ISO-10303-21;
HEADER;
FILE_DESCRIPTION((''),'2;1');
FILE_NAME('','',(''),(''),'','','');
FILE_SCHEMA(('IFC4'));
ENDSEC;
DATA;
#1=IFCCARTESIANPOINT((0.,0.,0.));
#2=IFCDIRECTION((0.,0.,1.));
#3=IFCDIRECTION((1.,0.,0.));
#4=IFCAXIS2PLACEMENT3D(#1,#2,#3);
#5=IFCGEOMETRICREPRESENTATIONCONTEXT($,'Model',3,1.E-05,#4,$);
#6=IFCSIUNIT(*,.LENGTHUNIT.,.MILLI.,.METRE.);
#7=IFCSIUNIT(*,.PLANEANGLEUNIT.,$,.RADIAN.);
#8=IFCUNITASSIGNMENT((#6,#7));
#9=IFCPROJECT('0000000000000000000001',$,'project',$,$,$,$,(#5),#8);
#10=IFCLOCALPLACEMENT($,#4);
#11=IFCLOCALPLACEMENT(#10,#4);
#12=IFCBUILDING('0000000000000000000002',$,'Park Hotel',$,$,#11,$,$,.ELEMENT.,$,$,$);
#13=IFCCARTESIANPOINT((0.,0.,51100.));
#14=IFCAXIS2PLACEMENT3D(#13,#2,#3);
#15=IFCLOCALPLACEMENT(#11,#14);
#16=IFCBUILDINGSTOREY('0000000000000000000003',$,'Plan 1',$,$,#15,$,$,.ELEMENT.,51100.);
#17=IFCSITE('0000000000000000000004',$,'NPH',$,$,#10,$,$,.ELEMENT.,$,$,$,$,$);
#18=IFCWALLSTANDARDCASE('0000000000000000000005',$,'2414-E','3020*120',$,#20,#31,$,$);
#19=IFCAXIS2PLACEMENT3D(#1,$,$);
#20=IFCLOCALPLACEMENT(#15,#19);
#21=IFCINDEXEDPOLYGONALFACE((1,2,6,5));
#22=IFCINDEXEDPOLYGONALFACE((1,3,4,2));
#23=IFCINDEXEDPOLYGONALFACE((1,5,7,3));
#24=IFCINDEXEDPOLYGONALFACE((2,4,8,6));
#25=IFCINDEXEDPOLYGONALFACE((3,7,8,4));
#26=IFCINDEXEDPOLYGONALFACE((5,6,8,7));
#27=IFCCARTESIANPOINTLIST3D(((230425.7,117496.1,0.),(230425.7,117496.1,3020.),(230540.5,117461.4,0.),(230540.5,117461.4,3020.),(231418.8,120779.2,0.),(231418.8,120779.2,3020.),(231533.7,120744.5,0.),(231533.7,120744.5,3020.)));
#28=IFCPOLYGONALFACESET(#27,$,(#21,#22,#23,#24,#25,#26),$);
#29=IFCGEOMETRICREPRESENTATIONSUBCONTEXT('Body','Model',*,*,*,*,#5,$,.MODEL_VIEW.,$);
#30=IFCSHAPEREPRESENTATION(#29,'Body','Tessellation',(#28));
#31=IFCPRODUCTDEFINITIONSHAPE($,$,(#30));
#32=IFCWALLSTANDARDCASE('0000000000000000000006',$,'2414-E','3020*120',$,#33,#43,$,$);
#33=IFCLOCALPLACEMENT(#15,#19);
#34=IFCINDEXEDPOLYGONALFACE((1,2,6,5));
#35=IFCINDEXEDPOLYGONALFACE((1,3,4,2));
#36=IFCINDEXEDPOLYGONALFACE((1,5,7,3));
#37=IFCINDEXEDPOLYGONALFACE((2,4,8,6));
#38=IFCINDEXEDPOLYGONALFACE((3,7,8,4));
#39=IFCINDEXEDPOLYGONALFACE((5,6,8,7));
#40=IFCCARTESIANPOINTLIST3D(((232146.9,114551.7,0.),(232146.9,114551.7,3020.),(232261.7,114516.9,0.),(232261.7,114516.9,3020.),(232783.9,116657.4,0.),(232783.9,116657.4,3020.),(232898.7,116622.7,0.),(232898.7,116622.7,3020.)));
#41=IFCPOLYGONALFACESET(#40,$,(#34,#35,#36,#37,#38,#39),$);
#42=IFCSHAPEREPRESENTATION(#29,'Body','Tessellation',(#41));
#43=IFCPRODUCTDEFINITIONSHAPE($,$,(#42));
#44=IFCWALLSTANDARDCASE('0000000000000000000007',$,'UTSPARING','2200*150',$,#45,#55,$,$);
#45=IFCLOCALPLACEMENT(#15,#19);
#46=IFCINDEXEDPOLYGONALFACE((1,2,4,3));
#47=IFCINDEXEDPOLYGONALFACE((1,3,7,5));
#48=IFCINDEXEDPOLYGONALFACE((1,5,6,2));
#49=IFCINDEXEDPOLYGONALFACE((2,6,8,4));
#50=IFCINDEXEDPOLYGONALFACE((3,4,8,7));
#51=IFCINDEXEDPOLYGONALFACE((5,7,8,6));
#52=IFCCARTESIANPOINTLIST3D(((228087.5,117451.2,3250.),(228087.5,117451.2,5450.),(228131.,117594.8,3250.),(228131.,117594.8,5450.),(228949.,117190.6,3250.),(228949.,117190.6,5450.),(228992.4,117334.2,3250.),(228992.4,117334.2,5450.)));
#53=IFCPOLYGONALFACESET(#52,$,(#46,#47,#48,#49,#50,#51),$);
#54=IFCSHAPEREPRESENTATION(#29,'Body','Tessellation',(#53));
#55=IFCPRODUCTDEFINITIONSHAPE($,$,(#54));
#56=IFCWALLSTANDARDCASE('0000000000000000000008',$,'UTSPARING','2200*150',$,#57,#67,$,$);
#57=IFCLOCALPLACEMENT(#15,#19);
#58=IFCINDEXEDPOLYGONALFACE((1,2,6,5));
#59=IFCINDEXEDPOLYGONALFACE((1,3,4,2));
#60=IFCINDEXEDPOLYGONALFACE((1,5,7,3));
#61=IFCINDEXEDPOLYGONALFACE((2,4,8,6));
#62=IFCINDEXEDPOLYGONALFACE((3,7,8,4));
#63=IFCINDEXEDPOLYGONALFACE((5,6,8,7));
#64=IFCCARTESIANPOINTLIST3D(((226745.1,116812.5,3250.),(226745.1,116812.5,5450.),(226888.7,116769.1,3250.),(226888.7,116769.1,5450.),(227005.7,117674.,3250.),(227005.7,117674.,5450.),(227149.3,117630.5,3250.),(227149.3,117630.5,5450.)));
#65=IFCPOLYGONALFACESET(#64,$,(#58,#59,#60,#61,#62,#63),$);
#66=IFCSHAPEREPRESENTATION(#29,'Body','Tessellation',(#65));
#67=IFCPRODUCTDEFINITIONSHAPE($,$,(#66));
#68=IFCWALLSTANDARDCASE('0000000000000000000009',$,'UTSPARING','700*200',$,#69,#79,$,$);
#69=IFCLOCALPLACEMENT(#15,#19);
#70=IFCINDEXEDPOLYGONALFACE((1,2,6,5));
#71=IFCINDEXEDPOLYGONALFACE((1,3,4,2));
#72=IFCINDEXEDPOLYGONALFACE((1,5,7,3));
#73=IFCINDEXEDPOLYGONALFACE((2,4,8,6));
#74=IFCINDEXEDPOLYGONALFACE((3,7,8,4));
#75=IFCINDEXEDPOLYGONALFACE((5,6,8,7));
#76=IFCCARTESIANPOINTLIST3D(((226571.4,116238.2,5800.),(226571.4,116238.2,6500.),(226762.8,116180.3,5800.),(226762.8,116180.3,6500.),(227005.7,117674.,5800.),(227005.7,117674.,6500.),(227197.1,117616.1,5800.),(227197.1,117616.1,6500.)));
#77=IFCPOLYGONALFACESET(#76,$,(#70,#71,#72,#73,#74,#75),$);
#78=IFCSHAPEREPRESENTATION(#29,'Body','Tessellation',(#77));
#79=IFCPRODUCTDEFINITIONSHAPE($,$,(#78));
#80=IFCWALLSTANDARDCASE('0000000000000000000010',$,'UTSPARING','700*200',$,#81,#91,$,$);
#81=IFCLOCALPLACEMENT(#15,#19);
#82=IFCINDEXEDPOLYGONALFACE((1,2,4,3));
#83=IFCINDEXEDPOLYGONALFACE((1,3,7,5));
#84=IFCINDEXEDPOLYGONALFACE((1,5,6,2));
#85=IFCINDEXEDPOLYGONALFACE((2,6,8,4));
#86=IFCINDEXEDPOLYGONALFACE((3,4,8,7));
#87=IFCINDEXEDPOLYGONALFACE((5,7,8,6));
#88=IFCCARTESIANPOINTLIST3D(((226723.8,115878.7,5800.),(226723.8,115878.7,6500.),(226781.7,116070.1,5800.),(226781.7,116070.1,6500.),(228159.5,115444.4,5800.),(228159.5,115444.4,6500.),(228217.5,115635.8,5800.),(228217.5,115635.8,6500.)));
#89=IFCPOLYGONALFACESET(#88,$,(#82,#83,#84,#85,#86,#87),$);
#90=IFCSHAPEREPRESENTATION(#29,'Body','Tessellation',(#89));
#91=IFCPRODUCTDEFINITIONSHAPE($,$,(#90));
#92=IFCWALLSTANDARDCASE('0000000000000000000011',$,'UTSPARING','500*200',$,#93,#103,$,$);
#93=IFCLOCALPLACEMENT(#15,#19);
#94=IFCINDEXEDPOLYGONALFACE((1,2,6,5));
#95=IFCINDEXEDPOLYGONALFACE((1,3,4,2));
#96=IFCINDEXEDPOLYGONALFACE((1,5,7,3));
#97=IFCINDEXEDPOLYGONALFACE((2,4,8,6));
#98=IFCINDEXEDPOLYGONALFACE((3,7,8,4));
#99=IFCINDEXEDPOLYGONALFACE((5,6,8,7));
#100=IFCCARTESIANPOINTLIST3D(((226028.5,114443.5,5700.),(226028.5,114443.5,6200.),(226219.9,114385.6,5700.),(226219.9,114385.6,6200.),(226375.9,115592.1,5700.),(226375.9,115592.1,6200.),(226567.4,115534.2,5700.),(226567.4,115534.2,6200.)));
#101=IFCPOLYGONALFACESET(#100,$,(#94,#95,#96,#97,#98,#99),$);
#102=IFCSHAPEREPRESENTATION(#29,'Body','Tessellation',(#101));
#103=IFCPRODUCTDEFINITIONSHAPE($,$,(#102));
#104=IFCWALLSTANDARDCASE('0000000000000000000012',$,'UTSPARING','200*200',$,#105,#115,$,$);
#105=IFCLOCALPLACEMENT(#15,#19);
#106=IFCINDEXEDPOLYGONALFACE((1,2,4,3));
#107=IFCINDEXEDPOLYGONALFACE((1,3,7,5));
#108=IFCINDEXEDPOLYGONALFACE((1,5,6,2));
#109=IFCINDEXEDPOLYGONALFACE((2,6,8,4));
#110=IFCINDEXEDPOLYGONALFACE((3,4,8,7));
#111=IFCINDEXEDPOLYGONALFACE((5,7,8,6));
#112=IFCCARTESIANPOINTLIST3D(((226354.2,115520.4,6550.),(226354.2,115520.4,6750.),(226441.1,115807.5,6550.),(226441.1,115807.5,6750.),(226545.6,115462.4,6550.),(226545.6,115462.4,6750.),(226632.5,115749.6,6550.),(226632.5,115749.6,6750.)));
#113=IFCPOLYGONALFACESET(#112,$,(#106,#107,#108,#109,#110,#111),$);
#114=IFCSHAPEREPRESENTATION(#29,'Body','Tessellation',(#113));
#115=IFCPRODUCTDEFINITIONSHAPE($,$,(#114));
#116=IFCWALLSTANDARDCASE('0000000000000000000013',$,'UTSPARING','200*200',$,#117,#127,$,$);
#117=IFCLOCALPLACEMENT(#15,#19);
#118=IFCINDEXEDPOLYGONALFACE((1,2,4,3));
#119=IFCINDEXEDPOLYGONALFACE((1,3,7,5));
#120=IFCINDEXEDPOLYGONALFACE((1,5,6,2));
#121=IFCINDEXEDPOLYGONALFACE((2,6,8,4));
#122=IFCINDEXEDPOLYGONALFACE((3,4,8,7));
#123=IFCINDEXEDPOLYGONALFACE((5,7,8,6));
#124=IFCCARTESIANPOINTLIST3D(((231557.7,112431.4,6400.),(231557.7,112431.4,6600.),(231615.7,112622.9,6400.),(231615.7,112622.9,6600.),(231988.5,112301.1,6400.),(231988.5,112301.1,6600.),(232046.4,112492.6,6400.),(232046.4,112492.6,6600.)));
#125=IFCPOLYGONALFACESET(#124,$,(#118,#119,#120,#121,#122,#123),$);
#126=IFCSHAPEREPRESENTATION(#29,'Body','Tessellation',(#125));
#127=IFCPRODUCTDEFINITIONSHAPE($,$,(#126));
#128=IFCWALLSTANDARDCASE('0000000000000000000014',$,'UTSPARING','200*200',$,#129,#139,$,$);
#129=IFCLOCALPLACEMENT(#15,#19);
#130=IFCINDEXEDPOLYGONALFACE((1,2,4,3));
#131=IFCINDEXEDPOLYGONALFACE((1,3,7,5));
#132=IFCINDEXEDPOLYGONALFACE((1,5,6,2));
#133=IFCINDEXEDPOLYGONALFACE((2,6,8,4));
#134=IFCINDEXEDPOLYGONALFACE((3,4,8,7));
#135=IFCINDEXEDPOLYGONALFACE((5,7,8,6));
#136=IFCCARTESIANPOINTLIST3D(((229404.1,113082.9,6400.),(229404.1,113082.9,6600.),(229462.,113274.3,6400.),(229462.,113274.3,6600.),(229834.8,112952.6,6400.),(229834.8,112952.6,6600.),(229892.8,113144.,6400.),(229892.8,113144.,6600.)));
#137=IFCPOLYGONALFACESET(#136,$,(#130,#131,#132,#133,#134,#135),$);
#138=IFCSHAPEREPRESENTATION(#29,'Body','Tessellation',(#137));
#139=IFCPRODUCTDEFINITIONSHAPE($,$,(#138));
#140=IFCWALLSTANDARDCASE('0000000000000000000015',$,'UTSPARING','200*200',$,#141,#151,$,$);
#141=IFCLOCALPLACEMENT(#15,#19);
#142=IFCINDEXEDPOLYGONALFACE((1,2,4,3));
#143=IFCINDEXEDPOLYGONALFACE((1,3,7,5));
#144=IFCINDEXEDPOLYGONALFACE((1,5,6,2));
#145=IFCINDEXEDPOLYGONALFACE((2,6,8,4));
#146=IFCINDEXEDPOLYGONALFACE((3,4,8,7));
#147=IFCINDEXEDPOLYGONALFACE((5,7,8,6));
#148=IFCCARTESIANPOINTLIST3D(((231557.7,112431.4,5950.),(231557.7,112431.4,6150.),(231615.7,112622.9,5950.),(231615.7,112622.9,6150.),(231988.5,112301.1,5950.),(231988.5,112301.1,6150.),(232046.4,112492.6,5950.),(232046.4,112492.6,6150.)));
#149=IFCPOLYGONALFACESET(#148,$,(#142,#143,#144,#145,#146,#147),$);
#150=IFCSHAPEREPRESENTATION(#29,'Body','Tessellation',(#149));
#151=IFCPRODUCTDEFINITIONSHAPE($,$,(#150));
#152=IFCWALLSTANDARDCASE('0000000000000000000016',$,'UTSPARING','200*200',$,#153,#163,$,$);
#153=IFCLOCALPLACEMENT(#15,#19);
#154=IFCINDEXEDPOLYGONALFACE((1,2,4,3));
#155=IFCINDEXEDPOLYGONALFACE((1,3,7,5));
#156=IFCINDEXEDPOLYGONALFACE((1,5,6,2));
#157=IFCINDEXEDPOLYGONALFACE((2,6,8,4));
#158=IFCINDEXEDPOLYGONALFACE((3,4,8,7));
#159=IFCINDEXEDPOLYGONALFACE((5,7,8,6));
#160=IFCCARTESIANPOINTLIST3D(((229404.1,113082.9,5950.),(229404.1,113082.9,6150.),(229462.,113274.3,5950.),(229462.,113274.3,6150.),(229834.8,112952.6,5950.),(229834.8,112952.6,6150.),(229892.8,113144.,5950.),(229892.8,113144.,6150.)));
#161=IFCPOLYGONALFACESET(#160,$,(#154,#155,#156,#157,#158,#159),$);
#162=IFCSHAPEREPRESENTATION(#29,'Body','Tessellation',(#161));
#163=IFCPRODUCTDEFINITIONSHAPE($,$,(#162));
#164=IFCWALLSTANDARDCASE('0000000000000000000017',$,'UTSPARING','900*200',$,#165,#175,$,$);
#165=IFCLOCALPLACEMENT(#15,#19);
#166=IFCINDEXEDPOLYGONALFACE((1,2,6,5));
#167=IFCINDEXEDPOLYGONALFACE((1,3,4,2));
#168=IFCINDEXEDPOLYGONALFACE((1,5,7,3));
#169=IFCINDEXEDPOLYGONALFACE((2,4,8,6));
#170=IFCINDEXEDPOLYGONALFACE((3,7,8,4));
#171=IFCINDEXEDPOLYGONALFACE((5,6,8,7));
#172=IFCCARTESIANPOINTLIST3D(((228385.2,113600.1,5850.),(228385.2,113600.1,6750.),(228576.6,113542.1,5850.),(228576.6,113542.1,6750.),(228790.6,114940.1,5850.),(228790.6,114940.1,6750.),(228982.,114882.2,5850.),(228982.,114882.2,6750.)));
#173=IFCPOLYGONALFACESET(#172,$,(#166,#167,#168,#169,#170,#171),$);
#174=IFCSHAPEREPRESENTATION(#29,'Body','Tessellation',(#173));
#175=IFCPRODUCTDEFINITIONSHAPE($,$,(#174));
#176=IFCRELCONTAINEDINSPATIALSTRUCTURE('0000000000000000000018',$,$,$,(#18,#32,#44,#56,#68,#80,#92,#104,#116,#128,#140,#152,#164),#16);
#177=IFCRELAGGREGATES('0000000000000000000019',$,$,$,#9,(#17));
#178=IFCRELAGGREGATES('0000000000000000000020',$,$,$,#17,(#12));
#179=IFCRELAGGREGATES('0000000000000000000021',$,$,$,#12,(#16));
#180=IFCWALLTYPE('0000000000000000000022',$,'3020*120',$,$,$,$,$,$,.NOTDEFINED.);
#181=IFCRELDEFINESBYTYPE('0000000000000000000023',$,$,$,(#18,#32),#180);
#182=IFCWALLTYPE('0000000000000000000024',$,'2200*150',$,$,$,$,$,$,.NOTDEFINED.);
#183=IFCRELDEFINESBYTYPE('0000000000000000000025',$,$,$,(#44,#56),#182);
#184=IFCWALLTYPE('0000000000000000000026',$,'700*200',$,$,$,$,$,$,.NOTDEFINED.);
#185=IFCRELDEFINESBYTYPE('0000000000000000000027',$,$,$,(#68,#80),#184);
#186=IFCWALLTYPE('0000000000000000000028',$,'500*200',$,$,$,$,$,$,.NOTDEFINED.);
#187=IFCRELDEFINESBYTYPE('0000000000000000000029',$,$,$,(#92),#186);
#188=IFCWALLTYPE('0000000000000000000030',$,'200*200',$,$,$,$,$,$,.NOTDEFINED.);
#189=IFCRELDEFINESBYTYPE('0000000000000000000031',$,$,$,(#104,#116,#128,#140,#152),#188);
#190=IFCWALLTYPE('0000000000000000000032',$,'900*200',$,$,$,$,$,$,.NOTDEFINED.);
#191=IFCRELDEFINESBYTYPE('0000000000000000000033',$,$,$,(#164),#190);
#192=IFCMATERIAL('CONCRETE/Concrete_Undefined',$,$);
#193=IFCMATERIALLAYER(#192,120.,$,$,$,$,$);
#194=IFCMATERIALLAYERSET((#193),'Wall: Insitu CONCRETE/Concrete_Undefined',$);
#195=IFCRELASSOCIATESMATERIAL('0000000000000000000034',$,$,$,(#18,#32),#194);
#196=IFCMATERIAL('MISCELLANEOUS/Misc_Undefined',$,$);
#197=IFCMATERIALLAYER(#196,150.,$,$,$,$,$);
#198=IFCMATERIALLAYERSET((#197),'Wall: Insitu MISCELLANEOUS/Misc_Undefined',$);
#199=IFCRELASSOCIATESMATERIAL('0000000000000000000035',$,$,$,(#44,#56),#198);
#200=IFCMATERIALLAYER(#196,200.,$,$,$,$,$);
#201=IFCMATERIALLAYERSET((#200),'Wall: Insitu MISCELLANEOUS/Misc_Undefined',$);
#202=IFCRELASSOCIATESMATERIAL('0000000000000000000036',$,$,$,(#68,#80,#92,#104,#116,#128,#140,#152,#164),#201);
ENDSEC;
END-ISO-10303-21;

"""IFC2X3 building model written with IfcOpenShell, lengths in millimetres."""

from ifc_helpers import new_model, si_unit, frame, frame_2d, origin_with_axes, place, context, subcontext, project, spatial, rectangle, extrude, material, layer, layer_set, layer_usage, type_object, element, save


model = new_model("IFC2X3")

# Units and contexts
model_context = context("Model", 3, precision=1e-05, world=origin_with_axes())
body_context = subcontext(model_context, "Body", "Model", "MODEL_VIEW")
ifc_project = project(units=[si_unit("LENGTHUNIT", "METRE", prefix="MILLI"), si_unit("PLANEANGLEUNIT", "RADIAN")], contexts=[model_context])

# Site, building, storey
site_placement = place(None, origin_with_axes())
site = spatial("IfcSite", under=ifc_project, at=site_placement, Name="NPH", CompositionType="ELEMENT")
building_placement = place(site_placement, origin_with_axes())
building = spatial("IfcBuilding", under=site, at=building_placement, Name="Park Hotel", CompositionType="ELEMENT")
storey_placement = place(building_placement, frame((0.0, 0.0, 51100.0), z_axis=(0.0, 0.0, 1.0), x_axis=(1.0, 0.0, 0.0)))
storey = spatial("IfcBuildingStorey", under=building, at=storey_placement, Name="Plan 1", CompositionType="ELEMENT", Elevation=51100.0)

# Shared definitions
ifc_material_1 = material(Name="CONCRETE/Concrete_Undefined")

# Walls
ifc_material_2 = material(Name="MISCELLANEOUS/Misc_Undefined")
ifc_layer_1 = layer(ifc_material_2, 150.0)
ifc_layer_set_1 = layer_set([ifc_layer_1], Name="Wall: Insitu MISCELLANEOUS/Misc_Undefined")
ifc_layer_2 = layer(ifc_material_1, 120.0)
ifc_layer_set_2 = layer_set([ifc_layer_2], Name="Wall: Insitu CONCRETE/Concrete_Undefined")
ifc_layer_usage_1 = layer_usage(ifc_layer_set_2, "AXIS2", "POSITIVE", -60.0)
wall_type_1 = type_object("IfcWallType", Name="3020*120", PredefinedType="NOTDEFINED")
wall_1_placement = place(storey_placement, frame((230483.1, 117478.8, 0.0), z_axis=(0.0, 0.0, 1.0), x_axis=(0.289539, 0.957166, 0.0)))
element("IfcWallStandardCase", 1, at=wall_1_placement, inside=storey, type_object=wall_type_1, material=ifc_layer_usage_1, Name="2414-E", Description="3020*120", context=body_context, shape_type="SweptSolid", body=[
    extrude(rectangle(XDim=3430.0, YDim=120.0, at=frame_2d((0.0, 1715.0), x_axis=(0.0, -1.0))), frame((0.0, 0.0, 0.0), z_axis=(0.0, 0.0, 1.0), x_axis=(0.0, -1.0, 0.0)), (0.0, 0.0, 1.0), 3020.0),
])
ifc_layer_usage_2 = layer_usage(ifc_layer_set_2, "AXIS2", "POSITIVE", -60.0)
wall_2_placement = place(storey_placement, frame((232204.3, 114534.3, 0.0), z_axis=(0.0, 0.0, 1.0), x_axis=(0.289541, 0.957166, 0.0)))
element("IfcWallStandardCase", 2, at=wall_2_placement, inside=storey, type_object=wall_type_1, material=ifc_layer_usage_2, Name="2414-E", Description="3020*120", context=body_context, shape_type="SweptSolid", body=[
    extrude(rectangle(XDim=2200.0, YDim=120.0, at=frame_2d((0.0, 1100.0), x_axis=(0.0, -1.0))), frame((0.0, 0.0, 0.0), z_axis=(0.0, 0.0, 1.0), x_axis=(0.0, -1.0, 0.0)), (0.0, 0.0, 1.0), 3020.0),
])
ifc_layer_usage_3 = layer_usage(ifc_layer_set_1, "AXIS2", "POSITIVE", -75.0)
wall_type_2 = type_object("IfcWallType", Name="2200*150", PredefinedType="NOTDEFINED")
wall_3_placement = place(storey_placement, frame((228970.7, 117262.4, 3250.0), z_axis=(0.0, 0.0, 1.0), x_axis=(-0.957165, 0.289542, 0.0)))
element("IfcWallStandardCase", 3, at=wall_3_placement, inside=storey, type_object=wall_type_2, material=ifc_layer_usage_3, Name="UTSPARING", Description="2200*150", context=body_context, shape_type="SweptSolid", body=[
    extrude(rectangle(XDim=900.0, YDim=150.0, at=frame_2d((0.0, 450.0), x_axis=(0.0, -1.0))), frame((0.0, 0.0, 0.0), z_axis=(0.0, 0.0, 1.0), x_axis=(0.0, -1.0, 0.0)), (0.0, 0.0, 1.0), 2200.0),
])
ifc_layer_usage_4 = layer_usage(ifc_layer_set_1, "AXIS2", "POSITIVE", -75.0)
wall_4_placement = place(storey_placement, frame((226816.9, 116790.8, 3250.0), z_axis=(0.0, 0.0, 1.0), x_axis=(0.289542, 0.957165, 0.0)))
element("IfcWallStandardCase", 4, at=wall_4_placement, inside=storey, type_object=wall_type_2, material=ifc_layer_usage_4, Name="UTSPARING", Description="2200*150", context=body_context, shape_type="SweptSolid", body=[
    extrude(rectangle(XDim=900.0, YDim=150.0, at=frame_2d((0.0, 450.0), x_axis=(0.0, -1.0))), frame((0.0, 0.0, 0.0), z_axis=(0.0, 0.0, 1.0), x_axis=(0.0, -1.0, 0.0)), (0.0, 0.0, 1.0), 2200.0),
])
ifc_layer_3 = layer(ifc_material_2, 200.0)
ifc_layer_set_3 = layer_set([ifc_layer_3], Name="Wall: Insitu MISCELLANEOUS/Misc_Undefined")
ifc_layer_usage_5 = layer_usage(ifc_layer_set_3, "AXIS2", "POSITIVE", -100.0)
wall_type_3 = type_object("IfcWallType", Name="700*200", PredefinedType="NOTDEFINED")
wall_5_placement = place(storey_placement, frame((227101.4, 117645.0, 5800.0), z_axis=(0.0, 0.0, 1.0), x_axis=(-0.289539, -0.957166, 0.0)))
element("IfcWallStandardCase", 5, at=wall_5_placement, inside=storey, type_object=wall_type_3, material=ifc_layer_usage_5, Name="UTSPARING", Description="700*200", context=body_context, shape_type="SweptSolid", body=[
    extrude(rectangle(XDim=1500.0, YDim=200.0, at=frame_2d((0.0, 750.0), x_axis=(0.0, -1.0))), frame((0.0, 0.0, 0.0), z_axis=(0.0, 0.0, 1.0), x_axis=(0.0, -1.0, 0.0)), (0.0, 0.0, 1.0), 700.0),
])
ifc_layer_usage_6 = layer_usage(ifc_layer_set_3, "AXIS2", "POSITIVE", -100.0)
wall_6_placement = place(storey_placement, frame((228188.5, 115540.1, 5800.0), z_axis=(0.0, 0.0, 1.0), x_axis=(-0.957166, 0.289539, 0.0)))
element("IfcWallStandardCase", 6, at=wall_6_placement, inside=storey, type_object=wall_type_3, material=ifc_layer_usage_6, Name="UTSPARING", Description="700*200", context=body_context, shape_type="SweptSolid", body=[
    extrude(rectangle(XDim=1500.0, YDim=200.0, at=frame_2d((0.0, 750.0), x_axis=(0.0, -1.0))), frame((0.0, 0.0, 0.0), z_axis=(0.0, 0.0, 1.0), x_axis=(0.0, -1.0, 0.0)), (0.0, 0.0, 1.0), 700.0),
])
ifc_layer_usage_7 = layer_usage(ifc_layer_set_3, "AXIS2", "POSITIVE", -100.0)
wall_type_4 = type_object("IfcWallType", Name="500*200", PredefinedType="NOTDEFINED")
wall_7_placement = place(storey_placement, frame((226471.7, 115563.2, 5700.0), z_axis=(0.0, 0.0, 1.0), x_axis=(-0.28954, -0.957166, 0.0)))
element("IfcWallStandardCase", 7, at=wall_7_placement, inside=storey, type_object=wall_type_4, material=ifc_layer_usage_7, Name="UTSPARING", Description="500*200", context=body_context, shape_type="SweptSolid", body=[
    extrude(rectangle(XDim=1200.0, YDim=200.0, at=frame_2d((0.0, 600.0), x_axis=(0.0, -1.0))), frame((0.0, 0.0, 0.0), z_axis=(0.0, 0.0, 1.0), x_axis=(0.0, -1.0, 0.0)), (0.0, 0.0, 1.0), 500.0),
])
ifc_layer_usage_8 = layer_usage(ifc_layer_set_3, "AXIS2", "POSITIVE", -100.0)
wall_type_5 = type_object("IfcWallType", Name="200*200", PredefinedType="NOTDEFINED")
wall_8_placement = place(storey_placement, frame((226536.8, 115778.5, 6550.0), z_axis=(0.0, 0.0, 1.0), x_axis=(-0.289549, -0.957163, 0.0)))
element("IfcWallStandardCase", 8, at=wall_8_placement, inside=storey, type_object=wall_type_5, material=ifc_layer_usage_8, Name="UTSPARING", Description="200*200", context=body_context, shape_type="SweptSolid", body=[
    extrude(rectangle(XDim=300.0, YDim=200.0, at=frame_2d((0.0, 150.0), x_axis=(0.0, -1.0))), frame((0.0, 0.0, 0.0), z_axis=(0.0, 0.0, 1.0), x_axis=(0.0, -1.0, 0.0)), (0.0, 0.0, 1.0), 200.0),
])
ifc_layer_usage_9 = layer_usage(ifc_layer_set_3, "AXIS2", "POSITIVE", -100.0)
wall_9_placement = place(storey_placement, frame((231586.7, 112527.1, 6400.0), z_axis=(0.0, 0.0, 1.0), x_axis=(0.957164, -0.289545, 0.0)))
element("IfcWallStandardCase", 9, at=wall_9_placement, inside=storey, type_object=wall_type_5, material=ifc_layer_usage_9, Name="UTSPARING", Description="200*200", context=body_context, shape_type="SweptSolid", body=[
    extrude(rectangle(XDim=450.0, YDim=200.0, at=frame_2d((0.0, 225.0), x_axis=(0.0, -1.0))), frame((0.0, 0.0, 0.0), z_axis=(0.0, 0.0, 1.0), x_axis=(0.0, -1.0, 0.0)), (0.0, 0.0, 1.0), 200.0),
])
ifc_layer_usage_10 = layer_usage(ifc_layer_set_3, "AXIS2", "POSITIVE", -100.0)
wall_10_placement = place(storey_placement, frame((229433.1, 113178.6, 6400.0), z_axis=(0.0, 0.0, 1.0), x_axis=(0.957164, -0.289545, 0.0)))
element("IfcWallStandardCase", 10, at=wall_10_placement, inside=storey, type_object=wall_type_5, material=ifc_layer_usage_10, Name="UTSPARING", Description="200*200", context=body_context, shape_type="SweptSolid", body=[
    extrude(rectangle(XDim=450.0, YDim=200.0, at=frame_2d((0.0, 225.0), x_axis=(0.0, -1.0))), frame((0.0, 0.0, 0.0), z_axis=(0.0, 0.0, 1.0), x_axis=(0.0, -1.0, 0.0)), (0.0, 0.0, 1.0), 200.0),
])
ifc_layer_usage_11 = layer_usage(ifc_layer_set_3, "AXIS2", "POSITIVE", -100.0)
wall_11_placement = place(storey_placement, frame((231586.7, 112527.1, 5950.0), z_axis=(0.0, 0.0, 1.0), x_axis=(0.957164, -0.289545, 0.0)))
element("IfcWallStandardCase", 11, at=wall_11_placement, inside=storey, type_object=wall_type_5, material=ifc_layer_usage_11, Name="UTSPARING", Description="200*200", context=body_context, shape_type="SweptSolid", body=[
    extrude(rectangle(XDim=450.0, YDim=200.0, at=frame_2d((0.0, 225.0), x_axis=(0.0, -1.0))), frame((0.0, 0.0, 0.0), z_axis=(0.0, 0.0, 1.0), x_axis=(0.0, -1.0, 0.0)), (0.0, 0.0, 1.0), 200.0),
])
ifc_layer_usage_12 = layer_usage(ifc_layer_set_3, "AXIS2", "POSITIVE", -100.0)
wall_12_placement = place(storey_placement, frame((229433.1, 113178.6, 5950.0), z_axis=(0.0, 0.0, 1.0), x_axis=(0.957164, -0.289545, 0.0)))
element("IfcWallStandardCase", 12, at=wall_12_placement, inside=storey, type_object=wall_type_5, material=ifc_layer_usage_12, Name="UTSPARING", Description="200*200", context=body_context, shape_type="SweptSolid", body=[
    extrude(rectangle(XDim=450.0, YDim=200.0, at=frame_2d((0.0, 225.0), x_axis=(0.0, -1.0))), frame((0.0, 0.0, 0.0), z_axis=(0.0, 0.0, 1.0), x_axis=(0.0, -1.0, 0.0)), (0.0, 0.0, 1.0), 200.0),
])
ifc_layer_usage_13 = layer_usage(ifc_layer_set_3, "AXIS2", "POSITIVE", -100.0)
wall_type_6 = type_object("IfcWallType", Name="900*200", PredefinedType="NOTDEFINED")
wall_13_placement = place(storey_placement, frame((228886.3, 114911.1, 5850.0), z_axis=(0.0, 0.0, 1.0), x_axis=(-0.289539, -0.957166, 0.0)))
element("IfcWallStandardCase", 13, at=wall_13_placement, inside=storey, type_object=wall_type_6, material=ifc_layer_usage_13, Name="UTSPARING", Description="900*200", context=body_context, shape_type="SweptSolid", body=[
    extrude(rectangle(XDim=1400.0, YDim=200.0, at=frame_2d((0.0, 700.0), x_axis=(0.0, -1.0))), frame((0.0, 0.0, 0.0), z_axis=(0.0, 0.0, 1.0), x_axis=(0.0, -1.0, 0.0)), (0.0, 0.0, 1.0), 900.0),
])

save(model, "model.ifc")
